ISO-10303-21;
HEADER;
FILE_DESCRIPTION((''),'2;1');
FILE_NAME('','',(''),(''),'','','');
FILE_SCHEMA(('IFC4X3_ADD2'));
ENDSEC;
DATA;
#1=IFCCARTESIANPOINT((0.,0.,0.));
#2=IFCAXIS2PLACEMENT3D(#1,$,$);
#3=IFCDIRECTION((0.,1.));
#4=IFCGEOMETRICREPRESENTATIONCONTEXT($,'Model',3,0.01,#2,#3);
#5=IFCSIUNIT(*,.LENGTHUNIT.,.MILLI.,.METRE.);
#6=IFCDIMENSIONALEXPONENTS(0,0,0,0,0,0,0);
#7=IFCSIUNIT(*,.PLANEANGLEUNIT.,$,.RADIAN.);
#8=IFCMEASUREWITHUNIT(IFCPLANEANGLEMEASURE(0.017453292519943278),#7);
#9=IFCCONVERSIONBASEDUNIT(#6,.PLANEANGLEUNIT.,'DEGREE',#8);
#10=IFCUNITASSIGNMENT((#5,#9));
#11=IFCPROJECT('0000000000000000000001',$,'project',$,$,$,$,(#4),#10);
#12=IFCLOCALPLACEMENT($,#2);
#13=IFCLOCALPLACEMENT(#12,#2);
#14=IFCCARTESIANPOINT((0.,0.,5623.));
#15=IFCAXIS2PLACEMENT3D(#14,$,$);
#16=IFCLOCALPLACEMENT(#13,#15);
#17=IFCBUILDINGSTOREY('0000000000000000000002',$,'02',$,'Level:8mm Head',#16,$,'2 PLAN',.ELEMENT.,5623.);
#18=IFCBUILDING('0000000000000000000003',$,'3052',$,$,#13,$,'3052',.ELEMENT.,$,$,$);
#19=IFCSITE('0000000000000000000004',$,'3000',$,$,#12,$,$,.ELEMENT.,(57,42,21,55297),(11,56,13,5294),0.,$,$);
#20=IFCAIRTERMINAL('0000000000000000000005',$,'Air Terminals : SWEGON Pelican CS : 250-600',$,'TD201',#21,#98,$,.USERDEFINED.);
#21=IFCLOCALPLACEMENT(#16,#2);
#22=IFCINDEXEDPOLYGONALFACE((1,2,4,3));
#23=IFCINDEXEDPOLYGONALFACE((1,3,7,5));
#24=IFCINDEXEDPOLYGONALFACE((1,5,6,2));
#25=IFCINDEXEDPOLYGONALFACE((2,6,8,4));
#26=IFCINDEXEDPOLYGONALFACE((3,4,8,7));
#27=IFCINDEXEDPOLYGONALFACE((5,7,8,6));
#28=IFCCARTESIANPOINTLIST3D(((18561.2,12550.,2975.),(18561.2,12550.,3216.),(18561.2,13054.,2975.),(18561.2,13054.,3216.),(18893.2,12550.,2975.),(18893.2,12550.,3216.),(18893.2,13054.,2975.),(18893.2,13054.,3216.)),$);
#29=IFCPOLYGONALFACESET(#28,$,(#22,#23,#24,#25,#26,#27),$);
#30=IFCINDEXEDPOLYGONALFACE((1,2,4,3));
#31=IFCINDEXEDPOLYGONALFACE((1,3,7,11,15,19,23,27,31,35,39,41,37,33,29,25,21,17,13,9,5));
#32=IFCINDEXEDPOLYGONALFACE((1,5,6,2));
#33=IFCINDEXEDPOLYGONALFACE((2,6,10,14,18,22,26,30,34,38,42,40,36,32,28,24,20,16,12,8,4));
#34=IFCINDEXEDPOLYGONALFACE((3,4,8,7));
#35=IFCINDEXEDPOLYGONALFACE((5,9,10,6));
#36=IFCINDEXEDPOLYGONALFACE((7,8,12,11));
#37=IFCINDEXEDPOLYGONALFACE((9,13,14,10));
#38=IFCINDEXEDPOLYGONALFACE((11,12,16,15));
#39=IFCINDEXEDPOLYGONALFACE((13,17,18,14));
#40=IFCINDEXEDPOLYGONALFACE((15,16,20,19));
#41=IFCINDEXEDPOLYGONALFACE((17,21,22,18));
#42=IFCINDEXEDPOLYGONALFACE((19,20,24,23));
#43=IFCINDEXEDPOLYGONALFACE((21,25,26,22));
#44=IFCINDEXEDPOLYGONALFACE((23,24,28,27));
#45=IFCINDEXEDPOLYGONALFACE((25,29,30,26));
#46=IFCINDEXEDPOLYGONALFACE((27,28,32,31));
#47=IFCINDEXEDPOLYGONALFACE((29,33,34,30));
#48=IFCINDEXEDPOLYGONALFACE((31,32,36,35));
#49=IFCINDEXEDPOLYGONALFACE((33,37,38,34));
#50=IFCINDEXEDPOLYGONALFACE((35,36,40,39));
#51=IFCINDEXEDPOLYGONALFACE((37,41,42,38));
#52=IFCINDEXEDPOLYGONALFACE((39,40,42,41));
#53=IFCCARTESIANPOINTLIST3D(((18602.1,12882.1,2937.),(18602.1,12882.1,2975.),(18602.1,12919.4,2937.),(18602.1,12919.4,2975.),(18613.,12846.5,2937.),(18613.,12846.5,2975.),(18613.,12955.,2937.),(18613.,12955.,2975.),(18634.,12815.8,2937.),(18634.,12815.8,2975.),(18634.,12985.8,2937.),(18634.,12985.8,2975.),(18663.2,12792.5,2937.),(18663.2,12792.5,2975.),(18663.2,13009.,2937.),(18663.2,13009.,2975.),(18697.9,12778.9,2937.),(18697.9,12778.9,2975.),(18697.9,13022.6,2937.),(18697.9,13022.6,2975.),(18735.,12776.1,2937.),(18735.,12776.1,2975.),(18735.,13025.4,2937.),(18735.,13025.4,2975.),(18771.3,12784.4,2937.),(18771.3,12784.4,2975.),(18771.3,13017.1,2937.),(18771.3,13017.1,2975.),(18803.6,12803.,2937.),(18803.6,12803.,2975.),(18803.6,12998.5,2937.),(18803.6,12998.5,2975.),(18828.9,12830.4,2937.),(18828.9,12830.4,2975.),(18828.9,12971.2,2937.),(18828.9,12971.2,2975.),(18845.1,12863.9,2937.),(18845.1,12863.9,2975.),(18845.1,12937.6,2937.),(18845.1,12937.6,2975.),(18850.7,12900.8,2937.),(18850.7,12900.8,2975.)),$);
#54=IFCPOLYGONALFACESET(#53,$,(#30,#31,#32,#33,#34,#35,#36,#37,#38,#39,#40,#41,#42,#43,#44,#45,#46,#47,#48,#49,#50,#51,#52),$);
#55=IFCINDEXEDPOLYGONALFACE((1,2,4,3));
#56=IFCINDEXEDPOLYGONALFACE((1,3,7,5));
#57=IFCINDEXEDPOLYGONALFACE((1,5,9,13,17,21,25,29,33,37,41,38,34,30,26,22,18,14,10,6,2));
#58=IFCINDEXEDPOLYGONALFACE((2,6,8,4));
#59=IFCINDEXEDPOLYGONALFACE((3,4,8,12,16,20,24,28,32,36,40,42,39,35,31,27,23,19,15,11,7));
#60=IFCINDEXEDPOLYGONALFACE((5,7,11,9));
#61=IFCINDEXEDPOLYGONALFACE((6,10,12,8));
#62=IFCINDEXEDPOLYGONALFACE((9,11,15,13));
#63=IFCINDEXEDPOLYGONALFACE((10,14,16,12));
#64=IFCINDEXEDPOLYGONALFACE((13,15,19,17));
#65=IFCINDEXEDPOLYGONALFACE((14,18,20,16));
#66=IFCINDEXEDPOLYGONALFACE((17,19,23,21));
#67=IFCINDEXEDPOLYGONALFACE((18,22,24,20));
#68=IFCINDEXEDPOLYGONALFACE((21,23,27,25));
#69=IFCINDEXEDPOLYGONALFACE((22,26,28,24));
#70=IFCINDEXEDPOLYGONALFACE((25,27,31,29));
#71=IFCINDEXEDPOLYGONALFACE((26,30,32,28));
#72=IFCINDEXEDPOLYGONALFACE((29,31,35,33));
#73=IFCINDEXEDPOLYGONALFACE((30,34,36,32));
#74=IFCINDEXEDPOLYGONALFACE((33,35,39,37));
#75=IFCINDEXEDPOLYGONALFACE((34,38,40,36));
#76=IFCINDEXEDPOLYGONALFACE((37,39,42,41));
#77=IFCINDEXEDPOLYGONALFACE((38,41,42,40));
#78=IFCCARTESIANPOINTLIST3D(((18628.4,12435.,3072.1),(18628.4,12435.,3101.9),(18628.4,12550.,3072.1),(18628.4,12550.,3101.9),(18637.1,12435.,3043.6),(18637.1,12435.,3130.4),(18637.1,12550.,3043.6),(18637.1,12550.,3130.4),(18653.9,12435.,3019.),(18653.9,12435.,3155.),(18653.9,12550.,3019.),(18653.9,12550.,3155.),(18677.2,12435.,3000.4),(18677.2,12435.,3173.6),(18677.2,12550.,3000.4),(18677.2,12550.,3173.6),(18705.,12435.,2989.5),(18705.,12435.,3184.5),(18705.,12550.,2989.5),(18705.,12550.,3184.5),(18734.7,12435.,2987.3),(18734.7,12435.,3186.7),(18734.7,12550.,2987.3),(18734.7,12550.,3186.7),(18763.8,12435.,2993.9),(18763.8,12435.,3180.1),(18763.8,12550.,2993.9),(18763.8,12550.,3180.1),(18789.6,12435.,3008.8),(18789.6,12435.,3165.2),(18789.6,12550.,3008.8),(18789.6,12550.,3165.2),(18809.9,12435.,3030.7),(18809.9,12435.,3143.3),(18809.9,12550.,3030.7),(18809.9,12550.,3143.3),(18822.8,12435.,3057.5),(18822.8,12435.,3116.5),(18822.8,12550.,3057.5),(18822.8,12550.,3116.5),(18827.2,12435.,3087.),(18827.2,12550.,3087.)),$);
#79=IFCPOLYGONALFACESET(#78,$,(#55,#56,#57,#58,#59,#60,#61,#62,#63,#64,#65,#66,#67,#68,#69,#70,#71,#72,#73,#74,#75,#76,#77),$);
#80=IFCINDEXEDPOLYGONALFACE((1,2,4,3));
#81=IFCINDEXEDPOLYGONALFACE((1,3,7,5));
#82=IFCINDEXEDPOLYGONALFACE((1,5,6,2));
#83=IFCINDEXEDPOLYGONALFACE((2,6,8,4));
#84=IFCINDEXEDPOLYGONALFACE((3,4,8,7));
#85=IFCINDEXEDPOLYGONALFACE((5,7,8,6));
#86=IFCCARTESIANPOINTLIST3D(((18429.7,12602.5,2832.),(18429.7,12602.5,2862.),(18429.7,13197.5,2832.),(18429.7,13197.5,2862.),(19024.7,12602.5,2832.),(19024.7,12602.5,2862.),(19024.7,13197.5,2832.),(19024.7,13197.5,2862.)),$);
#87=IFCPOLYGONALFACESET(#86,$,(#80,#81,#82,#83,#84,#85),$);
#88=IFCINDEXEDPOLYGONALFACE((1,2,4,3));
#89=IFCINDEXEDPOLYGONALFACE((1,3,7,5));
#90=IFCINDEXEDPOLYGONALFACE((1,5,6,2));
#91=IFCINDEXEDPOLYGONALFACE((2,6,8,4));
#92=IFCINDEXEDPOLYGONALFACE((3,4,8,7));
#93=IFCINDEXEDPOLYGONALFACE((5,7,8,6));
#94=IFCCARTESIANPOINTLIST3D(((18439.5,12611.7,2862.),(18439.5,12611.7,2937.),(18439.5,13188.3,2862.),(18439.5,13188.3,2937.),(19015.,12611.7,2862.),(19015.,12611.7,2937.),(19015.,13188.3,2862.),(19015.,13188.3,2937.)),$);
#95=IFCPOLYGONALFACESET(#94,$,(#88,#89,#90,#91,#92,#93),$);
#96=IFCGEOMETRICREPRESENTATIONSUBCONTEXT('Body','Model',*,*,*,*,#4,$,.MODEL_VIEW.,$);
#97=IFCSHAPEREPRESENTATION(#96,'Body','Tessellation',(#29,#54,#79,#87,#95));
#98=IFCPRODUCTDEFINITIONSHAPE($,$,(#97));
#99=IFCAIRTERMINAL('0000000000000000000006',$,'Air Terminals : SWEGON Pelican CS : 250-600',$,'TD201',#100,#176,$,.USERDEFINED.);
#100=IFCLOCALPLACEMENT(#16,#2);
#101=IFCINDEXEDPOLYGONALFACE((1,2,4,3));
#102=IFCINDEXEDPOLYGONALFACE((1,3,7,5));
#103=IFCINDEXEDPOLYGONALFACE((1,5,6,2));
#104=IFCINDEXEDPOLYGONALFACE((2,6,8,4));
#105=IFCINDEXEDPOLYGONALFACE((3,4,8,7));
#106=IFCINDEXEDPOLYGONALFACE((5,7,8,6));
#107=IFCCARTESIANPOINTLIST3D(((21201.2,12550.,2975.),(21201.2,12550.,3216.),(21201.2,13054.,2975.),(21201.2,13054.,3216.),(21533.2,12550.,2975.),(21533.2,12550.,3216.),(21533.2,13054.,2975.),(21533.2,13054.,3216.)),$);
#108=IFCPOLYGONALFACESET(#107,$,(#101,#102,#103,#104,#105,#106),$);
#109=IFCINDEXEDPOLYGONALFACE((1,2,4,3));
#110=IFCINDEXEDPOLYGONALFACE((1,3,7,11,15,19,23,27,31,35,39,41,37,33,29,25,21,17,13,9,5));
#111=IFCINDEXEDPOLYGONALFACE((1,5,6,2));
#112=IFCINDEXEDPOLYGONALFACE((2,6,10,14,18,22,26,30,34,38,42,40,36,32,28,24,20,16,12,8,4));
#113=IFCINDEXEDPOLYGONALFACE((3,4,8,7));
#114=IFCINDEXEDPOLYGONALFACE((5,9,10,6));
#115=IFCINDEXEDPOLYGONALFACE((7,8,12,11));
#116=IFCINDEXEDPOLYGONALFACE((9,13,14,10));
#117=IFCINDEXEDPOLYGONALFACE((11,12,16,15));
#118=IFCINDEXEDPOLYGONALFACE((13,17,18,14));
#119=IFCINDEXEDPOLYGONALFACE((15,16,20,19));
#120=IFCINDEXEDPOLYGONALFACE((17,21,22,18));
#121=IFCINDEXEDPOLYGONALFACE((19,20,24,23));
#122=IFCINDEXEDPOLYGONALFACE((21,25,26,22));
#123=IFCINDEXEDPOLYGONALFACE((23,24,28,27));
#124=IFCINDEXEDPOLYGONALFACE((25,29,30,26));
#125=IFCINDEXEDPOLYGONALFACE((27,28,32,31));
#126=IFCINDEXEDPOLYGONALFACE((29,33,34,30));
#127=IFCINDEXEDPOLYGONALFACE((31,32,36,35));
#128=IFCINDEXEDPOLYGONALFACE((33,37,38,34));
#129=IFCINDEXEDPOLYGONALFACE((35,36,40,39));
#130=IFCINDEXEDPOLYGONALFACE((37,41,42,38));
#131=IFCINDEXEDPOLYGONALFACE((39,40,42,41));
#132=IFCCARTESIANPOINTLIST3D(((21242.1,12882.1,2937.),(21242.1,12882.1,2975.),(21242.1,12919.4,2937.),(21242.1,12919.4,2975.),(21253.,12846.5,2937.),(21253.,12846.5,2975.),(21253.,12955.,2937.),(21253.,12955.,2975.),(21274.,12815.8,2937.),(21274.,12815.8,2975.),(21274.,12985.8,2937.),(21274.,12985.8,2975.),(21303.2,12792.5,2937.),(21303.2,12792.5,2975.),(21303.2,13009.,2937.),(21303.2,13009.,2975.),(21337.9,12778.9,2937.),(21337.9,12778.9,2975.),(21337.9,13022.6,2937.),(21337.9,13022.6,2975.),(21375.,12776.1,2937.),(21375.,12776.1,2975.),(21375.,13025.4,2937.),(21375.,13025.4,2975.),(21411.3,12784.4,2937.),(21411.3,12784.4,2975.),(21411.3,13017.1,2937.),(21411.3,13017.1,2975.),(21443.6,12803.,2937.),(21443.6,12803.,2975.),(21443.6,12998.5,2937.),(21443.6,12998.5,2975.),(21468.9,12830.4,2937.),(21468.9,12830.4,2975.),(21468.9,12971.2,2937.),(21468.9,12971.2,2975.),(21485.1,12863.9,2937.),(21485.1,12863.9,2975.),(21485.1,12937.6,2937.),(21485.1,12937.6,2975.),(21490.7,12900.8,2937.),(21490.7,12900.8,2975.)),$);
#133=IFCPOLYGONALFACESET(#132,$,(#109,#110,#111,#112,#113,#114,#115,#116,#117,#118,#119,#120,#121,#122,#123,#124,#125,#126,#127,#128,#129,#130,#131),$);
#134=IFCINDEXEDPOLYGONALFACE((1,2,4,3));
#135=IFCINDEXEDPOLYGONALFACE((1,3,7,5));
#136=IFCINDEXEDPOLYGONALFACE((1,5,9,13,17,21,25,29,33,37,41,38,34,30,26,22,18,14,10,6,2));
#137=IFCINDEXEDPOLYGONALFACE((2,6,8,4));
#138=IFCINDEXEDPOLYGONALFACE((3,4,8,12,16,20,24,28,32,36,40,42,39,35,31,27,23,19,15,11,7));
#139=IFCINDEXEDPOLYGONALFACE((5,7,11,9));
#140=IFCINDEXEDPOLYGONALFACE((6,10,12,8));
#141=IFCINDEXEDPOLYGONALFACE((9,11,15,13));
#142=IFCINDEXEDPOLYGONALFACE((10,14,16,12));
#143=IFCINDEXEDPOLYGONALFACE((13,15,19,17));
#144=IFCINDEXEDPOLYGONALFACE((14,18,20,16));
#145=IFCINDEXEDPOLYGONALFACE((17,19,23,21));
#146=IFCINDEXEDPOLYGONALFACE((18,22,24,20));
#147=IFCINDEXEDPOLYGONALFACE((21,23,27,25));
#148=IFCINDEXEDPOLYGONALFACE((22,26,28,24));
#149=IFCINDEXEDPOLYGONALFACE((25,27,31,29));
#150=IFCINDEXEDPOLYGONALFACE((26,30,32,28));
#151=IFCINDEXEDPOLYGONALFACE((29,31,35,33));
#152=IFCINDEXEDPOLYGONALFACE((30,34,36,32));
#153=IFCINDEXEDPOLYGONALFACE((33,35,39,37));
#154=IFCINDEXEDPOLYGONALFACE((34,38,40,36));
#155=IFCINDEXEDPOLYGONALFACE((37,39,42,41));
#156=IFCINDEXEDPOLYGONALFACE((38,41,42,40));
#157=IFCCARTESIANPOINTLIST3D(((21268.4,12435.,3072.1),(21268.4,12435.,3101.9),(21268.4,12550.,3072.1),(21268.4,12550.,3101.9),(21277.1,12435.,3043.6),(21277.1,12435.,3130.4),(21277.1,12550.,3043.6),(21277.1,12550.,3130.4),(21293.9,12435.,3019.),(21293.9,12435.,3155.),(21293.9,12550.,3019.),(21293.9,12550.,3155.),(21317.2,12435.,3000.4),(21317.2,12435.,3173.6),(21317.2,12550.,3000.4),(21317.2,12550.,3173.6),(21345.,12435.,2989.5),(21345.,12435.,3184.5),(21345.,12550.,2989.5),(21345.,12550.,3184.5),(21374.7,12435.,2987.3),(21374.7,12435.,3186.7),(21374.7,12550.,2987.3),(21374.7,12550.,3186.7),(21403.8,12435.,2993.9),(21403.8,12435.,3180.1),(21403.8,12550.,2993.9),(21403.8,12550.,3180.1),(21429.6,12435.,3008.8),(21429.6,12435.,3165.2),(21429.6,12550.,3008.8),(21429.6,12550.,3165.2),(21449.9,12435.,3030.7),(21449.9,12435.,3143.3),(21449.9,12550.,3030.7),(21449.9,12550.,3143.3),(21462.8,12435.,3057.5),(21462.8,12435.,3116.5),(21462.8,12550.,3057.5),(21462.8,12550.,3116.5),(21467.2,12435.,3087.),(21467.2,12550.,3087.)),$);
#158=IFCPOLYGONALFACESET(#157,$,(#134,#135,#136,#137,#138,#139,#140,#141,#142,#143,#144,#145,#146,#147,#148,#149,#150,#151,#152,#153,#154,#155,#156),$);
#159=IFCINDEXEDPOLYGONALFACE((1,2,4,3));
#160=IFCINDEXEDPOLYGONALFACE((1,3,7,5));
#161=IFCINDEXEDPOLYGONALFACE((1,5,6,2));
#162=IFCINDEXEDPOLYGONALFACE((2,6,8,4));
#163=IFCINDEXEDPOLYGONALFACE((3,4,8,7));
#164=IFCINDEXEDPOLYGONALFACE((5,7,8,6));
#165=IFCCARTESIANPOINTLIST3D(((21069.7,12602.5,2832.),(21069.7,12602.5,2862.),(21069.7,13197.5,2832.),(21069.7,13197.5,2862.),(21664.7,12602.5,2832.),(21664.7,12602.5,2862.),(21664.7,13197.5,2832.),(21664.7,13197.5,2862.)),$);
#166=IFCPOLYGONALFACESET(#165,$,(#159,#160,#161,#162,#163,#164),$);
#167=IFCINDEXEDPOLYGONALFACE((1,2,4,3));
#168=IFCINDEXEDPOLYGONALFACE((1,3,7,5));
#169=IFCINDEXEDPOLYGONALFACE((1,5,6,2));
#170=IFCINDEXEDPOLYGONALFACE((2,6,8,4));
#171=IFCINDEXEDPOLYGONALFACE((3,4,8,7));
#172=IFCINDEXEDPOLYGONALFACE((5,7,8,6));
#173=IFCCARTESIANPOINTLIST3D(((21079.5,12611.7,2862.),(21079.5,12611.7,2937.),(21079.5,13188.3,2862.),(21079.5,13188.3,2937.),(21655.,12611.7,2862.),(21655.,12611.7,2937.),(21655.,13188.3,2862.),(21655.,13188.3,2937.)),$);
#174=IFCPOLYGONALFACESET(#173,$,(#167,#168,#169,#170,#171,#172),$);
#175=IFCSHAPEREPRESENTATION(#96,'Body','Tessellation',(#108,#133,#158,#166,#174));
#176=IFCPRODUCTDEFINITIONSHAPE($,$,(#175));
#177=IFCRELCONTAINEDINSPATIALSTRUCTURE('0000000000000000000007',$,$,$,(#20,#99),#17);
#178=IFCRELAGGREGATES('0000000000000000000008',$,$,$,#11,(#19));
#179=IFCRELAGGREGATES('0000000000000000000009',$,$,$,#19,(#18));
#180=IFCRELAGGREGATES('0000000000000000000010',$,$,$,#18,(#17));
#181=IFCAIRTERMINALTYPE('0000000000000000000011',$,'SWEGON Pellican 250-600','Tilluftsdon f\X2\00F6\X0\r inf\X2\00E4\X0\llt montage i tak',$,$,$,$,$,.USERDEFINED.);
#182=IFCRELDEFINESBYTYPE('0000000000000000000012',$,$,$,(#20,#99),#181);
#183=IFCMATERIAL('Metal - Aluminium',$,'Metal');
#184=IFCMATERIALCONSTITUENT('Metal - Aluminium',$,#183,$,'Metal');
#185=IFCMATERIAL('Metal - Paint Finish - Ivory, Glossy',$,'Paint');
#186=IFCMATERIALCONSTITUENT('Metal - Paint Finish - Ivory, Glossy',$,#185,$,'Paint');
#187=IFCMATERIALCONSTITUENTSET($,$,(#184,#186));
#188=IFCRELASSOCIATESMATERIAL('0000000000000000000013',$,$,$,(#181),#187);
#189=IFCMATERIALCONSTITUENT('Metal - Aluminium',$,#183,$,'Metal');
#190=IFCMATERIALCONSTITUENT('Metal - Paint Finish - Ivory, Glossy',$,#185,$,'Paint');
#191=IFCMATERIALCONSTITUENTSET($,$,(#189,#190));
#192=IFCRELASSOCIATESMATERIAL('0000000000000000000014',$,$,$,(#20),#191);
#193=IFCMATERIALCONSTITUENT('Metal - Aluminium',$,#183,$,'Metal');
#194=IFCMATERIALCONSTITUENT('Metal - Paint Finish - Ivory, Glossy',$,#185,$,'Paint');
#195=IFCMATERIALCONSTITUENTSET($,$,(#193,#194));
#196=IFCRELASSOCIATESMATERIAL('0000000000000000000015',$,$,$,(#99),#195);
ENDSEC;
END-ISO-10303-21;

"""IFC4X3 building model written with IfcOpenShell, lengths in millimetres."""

from ifc_helpers import new_model, entity, si_unit, converted_unit, direction, frame, frame_2d, origin, origin_2d_with_axis, place, context, subcontext, project, spatial, rectangle, circle, extrude, source, transform, mapped, material, constituent, constituent_set, type_object, type_shapes, element, save


model = new_model("IFC4X3")

# Units and contexts
model_context = context("Model", 3, precision=0.01, world=origin(), true_north=direction((0.0, 1.0)))
body_context = subcontext(model_context, "Body", "Model", "MODEL_VIEW")
ifc_project = project(units=[si_unit("LENGTHUNIT", "METRE", prefix="MILLI"), converted_unit("PLANEANGLEUNIT", "DEGREE", entity("IfcPlaneAngleMeasure", 0.017453292519943278), si_unit("PLANEANGLEUNIT", "RADIAN"), dimensions=[0, 0, 0, 0, 0, 0, 0])], contexts=[model_context])

# Site, building, storey
site_placement = place(None, origin())
site = spatial("IfcSite", under=ifc_project, at=site_placement, Name="3000", CompositionType="ELEMENT", RefLatitude=(57, 42, 21, 55297), RefLongitude=(11, 56, 13, 5294), RefElevation=0.0)
building_placement = place(site_placement, origin())
building = spatial("IfcBuilding", under=site, at=building_placement, Name="3052", LongName="3052", CompositionType="ELEMENT")
storey_placement = place(building_placement, frame((0.0, 0.0, 5623.0)))
storey = spatial("IfcBuildingStorey", under=building, at=storey_placement, Name="02", ObjectType="Level:8mm Head", LongName="2 PLAN", CompositionType="ELEMENT", Elevation=5623.0)

# Air terminals
ifc_material_1 = material(Name="Metal - Aluminium", Category="Metal")
ifc_constituent_1 = constituent(ifc_material_1, Name="Metal - Aluminium", Category="Metal")
ifc_material_2 = material(Name="Metal - Paint Finish - Ivory, Glossy", Category="Paint")
ifc_constituent_2 = constituent(ifc_material_2, Name="Metal - Paint Finish - Ivory, Glossy", Category="Paint")
ifc_constituent_set_1 = constituent_set(constituents=[ifc_constituent_1, ifc_constituent_2])
ifc_constituent_3 = constituent(ifc_material_1, Name="Metal - Aluminium", Category="Metal")
ifc_constituent_4 = constituent(ifc_material_2, Name="Metal - Paint Finish - Ivory, Glossy", Category="Paint")
ifc_constituent_set_2 = constituent_set(constituents=[ifc_constituent_3, ifc_constituent_4])
air_terminal_type_1 = type_object("IfcAirTerminalType", Name="SWEGON Pellican 250-600", Description="Tilluftsdon för infällt montage i tak", PredefinedType="USERDEFINED", material=ifc_constituent_set_2)
shared_shape_1 = source(origin(), body_context, "Body", "SweptSolid", [
    extrude(rectangle(XDim=332.0, YDim=504.0, at=origin_2d_with_axis()), frame((0.0, 98.0, -354.0), z_axis=(0.0, 0.0, 1.0), x_axis=(-1.0, 0.0, 0.0)), (0.0, 0.0, 1.0), 241.0),
    extrude(circle(Radius=125.0, at=frame_2d((0.0, 0.0), x_axis=(1.0, 0.0))), frame((-1.6, -0.8, -113.0)), (0.0, 0.0, 1.0), 38.0),
    extrude(circle(Radius=100.0, at=frame_2d((0.0, 0.0), x_axis=(1.0, 0.0))), frame((0.0, 350.0, -225.0), z_axis=(0.0, 1.0, 0.0), x_axis=(1.0, 0.0, 0.0)), (0.0, 0.0, 1.0), 115.0),
    extrude(rectangle(XDim=595.0, YDim=595.0, at=frame_2d((0.0, 0.0), x_axis=(1.0, 0.0))), frame((0.0, 0.0, 0.0), z_axis=(0.0, 0.0, 1.0), x_axis=(-1.0, 0.0, 0.0)), (0.0, 0.0, 1.0), 30.0),
    extrude(rectangle(XDim=575.5, YDim=576.5, at=origin_2d_with_axis()), frame((0.0, 0.0, -75.0), z_axis=(0.0, 0.0, 1.0), x_axis=(-1.0, 0.0, 0.0)), (0.0, 0.0, 1.0), 75.0),
])
type_shapes(air_terminal_type_1, [shared_shape_1])
air_terminal_1_placement = place(storey_placement, frame((18727.2, 12900.0, 2862.0), z_axis=(0.0, 0.0, -1.0), x_axis=(1.0, 0.0, 0.0)))
element("IfcAirTerminal", 1, at=air_terminal_1_placement, inside=storey, type_object=air_terminal_type_1, material=ifc_constituent_set_1, Name="Air Terminals : SWEGON Pelican CS : 250-600", ObjectType="TD201", PredefinedType="USERDEFINED", context=body_context, shape_type="MappedRepresentation", body=[
    mapped(shared_shape_1, transform((0.0, 0.0, 0.0), scale=1.0)),
])
ifc_constituent_5 = constituent(ifc_material_1, Name="Metal - Aluminium", Category="Metal")
ifc_constituent_6 = constituent(ifc_material_2, Name="Metal - Paint Finish - Ivory, Glossy", Category="Paint")
ifc_constituent_set_3 = constituent_set(constituents=[ifc_constituent_5, ifc_constituent_6])
air_terminal_2_placement = place(storey_placement, frame((21367.2, 12900.0, 2862.0), z_axis=(0.0, 0.0, -1.0), x_axis=(1.0, 0.0, 0.0)))
element("IfcAirTerminal", 2, at=air_terminal_2_placement, inside=storey, type_object=air_terminal_type_1, material=ifc_constituent_set_3, Name="Air Terminals : SWEGON Pelican CS : 250-600", ObjectType="TD201", PredefinedType="USERDEFINED", context=body_context, shape_type="MappedRepresentation", body=[
    mapped(shared_shape_1, transform((0.0, 0.0, 0.0), scale=1.0)),
])

save(model, "model.ifc")
